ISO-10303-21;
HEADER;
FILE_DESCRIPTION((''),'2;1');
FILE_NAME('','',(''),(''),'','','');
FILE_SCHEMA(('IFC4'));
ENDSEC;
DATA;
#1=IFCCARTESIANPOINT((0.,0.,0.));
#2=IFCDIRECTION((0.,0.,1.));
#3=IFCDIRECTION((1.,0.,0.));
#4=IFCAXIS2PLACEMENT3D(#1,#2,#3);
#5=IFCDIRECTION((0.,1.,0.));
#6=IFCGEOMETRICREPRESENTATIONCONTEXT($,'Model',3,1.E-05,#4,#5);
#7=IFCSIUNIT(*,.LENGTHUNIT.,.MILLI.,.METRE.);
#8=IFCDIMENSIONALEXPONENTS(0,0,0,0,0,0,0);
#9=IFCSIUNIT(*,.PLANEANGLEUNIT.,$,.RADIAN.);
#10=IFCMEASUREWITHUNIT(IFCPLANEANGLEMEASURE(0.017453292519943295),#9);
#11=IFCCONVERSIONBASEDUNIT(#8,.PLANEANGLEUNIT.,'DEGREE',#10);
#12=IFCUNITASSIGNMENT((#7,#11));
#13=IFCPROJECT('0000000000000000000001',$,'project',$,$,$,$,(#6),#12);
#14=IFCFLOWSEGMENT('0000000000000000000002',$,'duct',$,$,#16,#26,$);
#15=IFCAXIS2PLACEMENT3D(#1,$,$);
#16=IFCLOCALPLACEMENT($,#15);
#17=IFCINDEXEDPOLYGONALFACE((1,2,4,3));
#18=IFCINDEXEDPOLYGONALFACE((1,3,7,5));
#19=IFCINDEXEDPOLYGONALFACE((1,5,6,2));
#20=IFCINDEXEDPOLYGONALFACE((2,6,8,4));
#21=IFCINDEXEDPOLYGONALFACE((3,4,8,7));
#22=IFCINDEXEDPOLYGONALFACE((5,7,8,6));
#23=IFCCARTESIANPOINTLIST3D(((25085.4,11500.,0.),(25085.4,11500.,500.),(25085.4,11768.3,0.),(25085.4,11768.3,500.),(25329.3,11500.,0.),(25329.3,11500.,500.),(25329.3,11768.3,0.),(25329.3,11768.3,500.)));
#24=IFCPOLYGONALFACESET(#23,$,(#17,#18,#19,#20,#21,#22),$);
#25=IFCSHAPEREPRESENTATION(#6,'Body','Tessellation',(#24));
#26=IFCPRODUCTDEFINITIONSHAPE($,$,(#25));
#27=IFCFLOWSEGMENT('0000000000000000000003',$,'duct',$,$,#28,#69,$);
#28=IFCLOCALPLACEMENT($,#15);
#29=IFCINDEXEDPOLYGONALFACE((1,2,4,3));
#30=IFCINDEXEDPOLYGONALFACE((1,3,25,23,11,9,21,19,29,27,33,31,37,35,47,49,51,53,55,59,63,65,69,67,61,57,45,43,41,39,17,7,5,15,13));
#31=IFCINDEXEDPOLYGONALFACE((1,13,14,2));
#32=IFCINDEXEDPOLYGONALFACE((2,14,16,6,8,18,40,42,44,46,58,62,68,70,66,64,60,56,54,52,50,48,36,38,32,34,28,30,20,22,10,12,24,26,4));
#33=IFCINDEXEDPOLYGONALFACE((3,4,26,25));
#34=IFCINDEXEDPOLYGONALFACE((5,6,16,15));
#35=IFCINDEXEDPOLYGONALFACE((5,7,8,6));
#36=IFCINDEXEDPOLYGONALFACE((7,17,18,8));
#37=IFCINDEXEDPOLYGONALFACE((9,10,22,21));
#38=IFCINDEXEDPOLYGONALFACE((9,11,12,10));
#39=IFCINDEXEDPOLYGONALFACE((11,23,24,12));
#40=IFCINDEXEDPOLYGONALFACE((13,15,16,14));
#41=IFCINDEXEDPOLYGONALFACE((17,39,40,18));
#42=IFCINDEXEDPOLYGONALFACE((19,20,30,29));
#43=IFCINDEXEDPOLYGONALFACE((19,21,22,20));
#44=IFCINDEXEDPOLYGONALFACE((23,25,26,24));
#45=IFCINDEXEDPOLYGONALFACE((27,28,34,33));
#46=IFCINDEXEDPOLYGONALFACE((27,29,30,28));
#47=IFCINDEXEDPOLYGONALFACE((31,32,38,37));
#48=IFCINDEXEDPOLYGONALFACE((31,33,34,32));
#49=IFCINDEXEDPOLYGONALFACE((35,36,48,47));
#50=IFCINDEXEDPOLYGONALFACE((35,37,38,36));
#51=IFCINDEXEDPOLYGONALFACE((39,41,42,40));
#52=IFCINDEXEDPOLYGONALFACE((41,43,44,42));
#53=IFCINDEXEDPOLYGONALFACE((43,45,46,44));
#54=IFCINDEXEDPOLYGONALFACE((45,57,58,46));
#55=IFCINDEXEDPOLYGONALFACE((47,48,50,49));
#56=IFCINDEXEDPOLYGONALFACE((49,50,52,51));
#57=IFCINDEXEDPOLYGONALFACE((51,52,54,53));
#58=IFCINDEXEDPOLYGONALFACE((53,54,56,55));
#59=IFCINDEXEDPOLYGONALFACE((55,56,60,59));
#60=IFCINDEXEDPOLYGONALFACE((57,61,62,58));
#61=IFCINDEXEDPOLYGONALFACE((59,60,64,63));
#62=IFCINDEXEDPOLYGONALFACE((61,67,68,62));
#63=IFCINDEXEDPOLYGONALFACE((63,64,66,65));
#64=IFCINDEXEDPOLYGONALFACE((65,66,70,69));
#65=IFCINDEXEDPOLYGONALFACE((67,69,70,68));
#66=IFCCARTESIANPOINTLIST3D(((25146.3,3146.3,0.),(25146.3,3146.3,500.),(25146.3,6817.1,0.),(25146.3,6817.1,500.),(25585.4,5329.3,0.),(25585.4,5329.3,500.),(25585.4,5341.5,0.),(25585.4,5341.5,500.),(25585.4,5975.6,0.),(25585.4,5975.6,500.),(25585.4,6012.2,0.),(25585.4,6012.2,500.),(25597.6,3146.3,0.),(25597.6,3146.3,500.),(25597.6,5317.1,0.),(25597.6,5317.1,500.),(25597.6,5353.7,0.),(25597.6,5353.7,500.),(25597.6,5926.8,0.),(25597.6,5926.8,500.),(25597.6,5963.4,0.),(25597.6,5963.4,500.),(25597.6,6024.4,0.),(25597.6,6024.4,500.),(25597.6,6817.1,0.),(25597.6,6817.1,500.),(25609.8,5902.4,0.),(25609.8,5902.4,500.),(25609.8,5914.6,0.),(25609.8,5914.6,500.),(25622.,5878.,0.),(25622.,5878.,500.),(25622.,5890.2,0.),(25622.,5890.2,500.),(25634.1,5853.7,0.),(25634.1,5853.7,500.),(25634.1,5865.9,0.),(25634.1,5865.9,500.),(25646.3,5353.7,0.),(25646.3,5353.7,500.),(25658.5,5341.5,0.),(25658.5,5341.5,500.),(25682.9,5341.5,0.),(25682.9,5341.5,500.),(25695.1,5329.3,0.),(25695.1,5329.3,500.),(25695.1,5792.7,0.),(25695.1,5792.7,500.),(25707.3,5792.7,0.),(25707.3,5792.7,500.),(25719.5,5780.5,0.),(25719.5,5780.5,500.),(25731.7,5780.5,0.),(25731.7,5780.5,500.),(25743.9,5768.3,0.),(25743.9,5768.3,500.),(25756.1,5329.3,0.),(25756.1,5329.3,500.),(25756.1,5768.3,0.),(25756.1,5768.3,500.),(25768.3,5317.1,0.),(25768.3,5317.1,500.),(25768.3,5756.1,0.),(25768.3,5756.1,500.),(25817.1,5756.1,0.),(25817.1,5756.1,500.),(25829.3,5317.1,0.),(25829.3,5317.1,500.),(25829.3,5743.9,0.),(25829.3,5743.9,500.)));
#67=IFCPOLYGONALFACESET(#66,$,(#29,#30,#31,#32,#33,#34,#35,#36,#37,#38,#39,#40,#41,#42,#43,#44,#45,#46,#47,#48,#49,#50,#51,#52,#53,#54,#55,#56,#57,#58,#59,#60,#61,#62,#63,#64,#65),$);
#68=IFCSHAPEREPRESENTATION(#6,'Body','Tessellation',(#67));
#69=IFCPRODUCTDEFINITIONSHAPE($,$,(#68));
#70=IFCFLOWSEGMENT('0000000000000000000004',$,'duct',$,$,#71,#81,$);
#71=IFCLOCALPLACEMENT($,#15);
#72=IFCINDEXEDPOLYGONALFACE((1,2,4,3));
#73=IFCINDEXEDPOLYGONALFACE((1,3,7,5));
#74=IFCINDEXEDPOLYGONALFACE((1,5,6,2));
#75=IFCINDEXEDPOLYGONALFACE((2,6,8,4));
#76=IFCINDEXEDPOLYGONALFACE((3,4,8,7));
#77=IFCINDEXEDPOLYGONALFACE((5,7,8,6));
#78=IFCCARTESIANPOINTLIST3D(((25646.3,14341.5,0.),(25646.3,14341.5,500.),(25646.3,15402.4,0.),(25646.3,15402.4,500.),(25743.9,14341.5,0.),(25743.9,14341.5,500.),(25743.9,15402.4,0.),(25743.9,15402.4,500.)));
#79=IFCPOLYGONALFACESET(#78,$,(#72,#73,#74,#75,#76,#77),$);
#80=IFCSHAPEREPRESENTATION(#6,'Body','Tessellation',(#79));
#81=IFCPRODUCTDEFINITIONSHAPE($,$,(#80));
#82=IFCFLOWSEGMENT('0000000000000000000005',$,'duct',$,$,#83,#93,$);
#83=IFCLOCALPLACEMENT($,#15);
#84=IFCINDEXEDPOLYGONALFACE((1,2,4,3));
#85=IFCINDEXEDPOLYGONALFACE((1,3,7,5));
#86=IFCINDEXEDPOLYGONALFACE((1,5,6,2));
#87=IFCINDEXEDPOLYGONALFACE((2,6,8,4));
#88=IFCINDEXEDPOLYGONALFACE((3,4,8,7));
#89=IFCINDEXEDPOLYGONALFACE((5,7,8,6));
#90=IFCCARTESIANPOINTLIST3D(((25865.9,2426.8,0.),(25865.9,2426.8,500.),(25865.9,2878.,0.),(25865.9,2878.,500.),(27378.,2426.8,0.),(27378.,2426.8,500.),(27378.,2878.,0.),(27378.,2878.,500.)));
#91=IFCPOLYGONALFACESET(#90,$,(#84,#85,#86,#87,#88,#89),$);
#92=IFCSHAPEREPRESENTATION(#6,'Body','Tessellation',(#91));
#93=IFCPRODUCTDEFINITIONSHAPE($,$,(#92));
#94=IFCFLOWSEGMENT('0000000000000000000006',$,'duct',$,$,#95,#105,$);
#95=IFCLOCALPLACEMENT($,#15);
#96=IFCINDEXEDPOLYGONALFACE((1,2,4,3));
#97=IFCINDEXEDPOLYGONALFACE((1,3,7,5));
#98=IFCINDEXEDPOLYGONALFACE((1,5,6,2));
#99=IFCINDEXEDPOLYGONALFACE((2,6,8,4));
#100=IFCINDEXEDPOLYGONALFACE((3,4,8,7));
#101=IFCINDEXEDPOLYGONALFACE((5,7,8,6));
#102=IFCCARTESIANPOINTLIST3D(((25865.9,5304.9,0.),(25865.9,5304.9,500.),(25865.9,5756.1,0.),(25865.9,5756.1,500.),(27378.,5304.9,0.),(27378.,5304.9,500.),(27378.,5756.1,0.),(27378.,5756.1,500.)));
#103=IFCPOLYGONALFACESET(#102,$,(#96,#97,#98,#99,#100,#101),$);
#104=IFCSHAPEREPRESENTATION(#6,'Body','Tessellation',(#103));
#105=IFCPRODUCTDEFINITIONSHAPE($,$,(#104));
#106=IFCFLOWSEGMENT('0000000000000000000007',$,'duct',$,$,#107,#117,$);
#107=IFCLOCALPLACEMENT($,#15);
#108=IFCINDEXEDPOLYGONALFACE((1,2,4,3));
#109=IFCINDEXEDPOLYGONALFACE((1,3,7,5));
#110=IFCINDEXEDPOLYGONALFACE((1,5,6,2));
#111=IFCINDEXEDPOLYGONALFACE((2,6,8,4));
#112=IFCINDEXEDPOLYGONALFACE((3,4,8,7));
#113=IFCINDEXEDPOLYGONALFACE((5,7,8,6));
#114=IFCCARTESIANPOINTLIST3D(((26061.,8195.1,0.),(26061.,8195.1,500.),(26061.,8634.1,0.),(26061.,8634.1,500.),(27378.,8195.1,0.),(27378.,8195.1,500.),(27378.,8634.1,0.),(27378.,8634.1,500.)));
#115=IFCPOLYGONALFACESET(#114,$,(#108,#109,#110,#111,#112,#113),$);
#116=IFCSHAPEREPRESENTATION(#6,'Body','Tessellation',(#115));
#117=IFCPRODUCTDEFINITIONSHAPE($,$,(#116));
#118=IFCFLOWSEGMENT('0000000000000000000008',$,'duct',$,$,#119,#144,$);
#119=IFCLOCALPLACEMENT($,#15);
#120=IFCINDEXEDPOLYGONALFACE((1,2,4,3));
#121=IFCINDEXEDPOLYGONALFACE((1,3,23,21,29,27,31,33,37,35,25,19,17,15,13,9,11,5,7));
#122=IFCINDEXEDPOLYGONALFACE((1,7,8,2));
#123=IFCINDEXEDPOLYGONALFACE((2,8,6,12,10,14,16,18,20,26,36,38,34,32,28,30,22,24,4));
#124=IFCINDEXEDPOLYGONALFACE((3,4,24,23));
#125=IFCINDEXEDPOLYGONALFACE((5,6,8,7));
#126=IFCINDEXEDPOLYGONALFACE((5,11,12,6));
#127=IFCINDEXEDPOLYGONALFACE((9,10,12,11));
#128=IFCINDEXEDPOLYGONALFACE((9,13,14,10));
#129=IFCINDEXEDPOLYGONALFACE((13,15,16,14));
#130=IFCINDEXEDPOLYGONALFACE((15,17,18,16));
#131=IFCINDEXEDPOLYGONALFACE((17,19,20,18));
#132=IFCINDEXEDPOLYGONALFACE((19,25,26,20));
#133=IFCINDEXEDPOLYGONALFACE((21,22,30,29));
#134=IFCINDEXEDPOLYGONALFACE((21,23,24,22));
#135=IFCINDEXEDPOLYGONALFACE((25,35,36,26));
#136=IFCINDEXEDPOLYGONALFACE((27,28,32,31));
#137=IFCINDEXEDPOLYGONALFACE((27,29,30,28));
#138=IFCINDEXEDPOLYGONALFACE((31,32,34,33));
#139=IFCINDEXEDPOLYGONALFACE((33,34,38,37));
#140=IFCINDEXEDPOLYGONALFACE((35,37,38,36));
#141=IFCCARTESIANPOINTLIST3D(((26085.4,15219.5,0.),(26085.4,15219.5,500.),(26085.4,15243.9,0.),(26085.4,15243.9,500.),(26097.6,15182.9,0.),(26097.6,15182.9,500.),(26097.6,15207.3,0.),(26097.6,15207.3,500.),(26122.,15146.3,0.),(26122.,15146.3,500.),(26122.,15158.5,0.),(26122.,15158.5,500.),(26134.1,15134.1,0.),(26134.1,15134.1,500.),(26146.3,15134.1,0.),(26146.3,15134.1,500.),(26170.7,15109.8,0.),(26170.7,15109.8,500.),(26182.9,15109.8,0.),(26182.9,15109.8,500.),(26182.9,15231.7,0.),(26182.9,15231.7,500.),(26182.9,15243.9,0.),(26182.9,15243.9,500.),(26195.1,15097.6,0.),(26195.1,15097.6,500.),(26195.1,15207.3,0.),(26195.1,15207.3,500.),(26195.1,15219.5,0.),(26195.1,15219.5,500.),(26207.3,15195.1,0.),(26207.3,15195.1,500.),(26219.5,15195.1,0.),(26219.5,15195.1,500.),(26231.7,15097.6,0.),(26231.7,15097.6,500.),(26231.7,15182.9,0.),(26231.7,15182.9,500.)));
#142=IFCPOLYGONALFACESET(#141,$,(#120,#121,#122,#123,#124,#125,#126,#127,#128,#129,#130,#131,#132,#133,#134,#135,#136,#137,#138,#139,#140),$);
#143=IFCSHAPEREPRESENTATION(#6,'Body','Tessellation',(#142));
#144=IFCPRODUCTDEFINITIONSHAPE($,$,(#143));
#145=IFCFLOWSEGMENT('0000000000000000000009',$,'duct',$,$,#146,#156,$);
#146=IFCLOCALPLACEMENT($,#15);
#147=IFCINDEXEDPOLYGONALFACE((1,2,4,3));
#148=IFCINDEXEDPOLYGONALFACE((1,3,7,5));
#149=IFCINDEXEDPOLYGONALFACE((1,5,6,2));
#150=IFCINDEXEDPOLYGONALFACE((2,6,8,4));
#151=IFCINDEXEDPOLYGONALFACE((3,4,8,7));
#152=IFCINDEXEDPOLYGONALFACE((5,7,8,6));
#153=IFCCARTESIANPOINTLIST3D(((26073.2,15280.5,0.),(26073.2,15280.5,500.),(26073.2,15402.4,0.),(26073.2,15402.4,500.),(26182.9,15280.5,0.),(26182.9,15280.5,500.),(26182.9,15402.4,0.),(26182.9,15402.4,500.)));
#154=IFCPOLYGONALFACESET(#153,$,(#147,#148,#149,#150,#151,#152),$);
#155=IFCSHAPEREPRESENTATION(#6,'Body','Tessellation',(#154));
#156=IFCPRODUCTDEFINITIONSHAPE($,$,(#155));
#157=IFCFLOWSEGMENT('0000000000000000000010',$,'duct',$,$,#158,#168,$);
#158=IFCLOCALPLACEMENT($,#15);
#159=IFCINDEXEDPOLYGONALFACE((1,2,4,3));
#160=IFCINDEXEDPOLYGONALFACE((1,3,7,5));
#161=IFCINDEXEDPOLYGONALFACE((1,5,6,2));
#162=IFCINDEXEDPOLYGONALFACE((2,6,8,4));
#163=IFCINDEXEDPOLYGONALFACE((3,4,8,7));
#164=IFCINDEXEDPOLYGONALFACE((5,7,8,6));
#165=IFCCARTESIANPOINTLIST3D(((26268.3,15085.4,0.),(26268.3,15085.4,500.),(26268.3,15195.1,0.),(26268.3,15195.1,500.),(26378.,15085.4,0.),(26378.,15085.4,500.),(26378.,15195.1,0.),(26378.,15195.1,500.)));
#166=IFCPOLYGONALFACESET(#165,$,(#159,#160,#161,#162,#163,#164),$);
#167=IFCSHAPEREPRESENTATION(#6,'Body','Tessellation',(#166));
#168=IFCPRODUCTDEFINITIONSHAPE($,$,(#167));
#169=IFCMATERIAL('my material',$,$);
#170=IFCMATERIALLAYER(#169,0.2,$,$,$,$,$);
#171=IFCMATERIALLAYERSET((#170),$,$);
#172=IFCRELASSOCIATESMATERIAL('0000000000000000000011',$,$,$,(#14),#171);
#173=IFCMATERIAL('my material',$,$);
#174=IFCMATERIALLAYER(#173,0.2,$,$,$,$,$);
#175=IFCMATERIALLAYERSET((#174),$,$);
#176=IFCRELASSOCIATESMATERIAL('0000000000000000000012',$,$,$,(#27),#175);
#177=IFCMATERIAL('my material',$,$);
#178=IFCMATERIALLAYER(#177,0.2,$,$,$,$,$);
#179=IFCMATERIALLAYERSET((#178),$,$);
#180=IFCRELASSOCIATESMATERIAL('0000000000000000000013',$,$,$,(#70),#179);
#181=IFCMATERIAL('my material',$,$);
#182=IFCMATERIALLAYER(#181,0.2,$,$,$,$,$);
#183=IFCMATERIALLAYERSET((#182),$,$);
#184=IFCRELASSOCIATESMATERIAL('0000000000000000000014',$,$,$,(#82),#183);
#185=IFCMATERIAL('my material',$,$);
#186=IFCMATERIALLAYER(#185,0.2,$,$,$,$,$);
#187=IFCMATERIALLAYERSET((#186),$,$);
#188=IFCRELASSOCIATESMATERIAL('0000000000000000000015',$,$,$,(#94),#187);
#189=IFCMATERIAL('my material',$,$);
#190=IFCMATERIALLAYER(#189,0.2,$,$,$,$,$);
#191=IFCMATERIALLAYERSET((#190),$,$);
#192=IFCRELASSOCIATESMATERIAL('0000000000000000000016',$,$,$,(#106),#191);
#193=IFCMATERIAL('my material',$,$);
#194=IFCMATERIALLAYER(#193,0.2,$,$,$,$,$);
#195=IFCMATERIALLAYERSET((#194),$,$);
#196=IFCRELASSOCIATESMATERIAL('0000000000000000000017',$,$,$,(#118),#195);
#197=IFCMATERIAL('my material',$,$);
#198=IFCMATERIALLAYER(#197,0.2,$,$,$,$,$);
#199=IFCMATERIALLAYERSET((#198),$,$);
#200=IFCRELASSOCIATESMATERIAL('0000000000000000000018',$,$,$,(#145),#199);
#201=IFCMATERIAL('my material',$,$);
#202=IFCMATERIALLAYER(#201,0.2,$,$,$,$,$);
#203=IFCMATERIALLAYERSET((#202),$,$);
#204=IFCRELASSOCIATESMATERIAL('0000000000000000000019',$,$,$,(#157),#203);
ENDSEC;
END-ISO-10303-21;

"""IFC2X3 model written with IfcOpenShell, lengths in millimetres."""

from ifc_helpers import new_model, entity, si_unit, converted_unit, direction, origin_with_axes, place, context, project, polyline, outline, extrude, material, layer, layer_set, layer_usage, element, save


model = new_model("IFC2X3")

# Units and contexts
model_context = context("Model", 3, precision=1e-05, world=origin_with_axes(), true_north=direction((0.0, 1.0, 0.0)))
ifc_project = project(units=[si_unit("LENGTHUNIT", "METRE", prefix="MILLI"), converted_unit("PLANEANGLEUNIT", "DEGREE", entity("IfcPlaneAngleMeasure", 0.017453292519943295), si_unit("PLANEANGLEUNIT", "RADIAN"), dimensions=[0, 0, 0, 0, 0, 0, 0])], contexts=[model_context])

# Flow segments
ifc_material_1 = material(Name="my material")
ifc_layer_1 = layer(ifc_material_1, 0.2)
ifc_layer_set_1 = layer_set([ifc_layer_1])
ifc_layer_usage_1 = layer_usage(ifc_layer_set_1, "AXIS2", "POSITIVE", -0.1)
flow_segment_1_placement = place(None, origin_with_axes())
element("IfcFlowSegment", 1, at=flow_segment_1_placement, material=ifc_layer_usage_1, Name="duct", context=model_context, shape_type="SweptSolid", body=[
    extrude(outline(polyline([(25085.4, 11500.0), (25329.3, 11500.0), (25329.3, 11768.3), (25085.4, 11768.3), (25085.4, 11500.0)])), origin_with_axes(), (0.0, 0.0, 1.0), 500.0),
])
ifc_material_2 = material(Name="my material")
ifc_layer_2 = layer(ifc_material_2, 0.2)
ifc_layer_set_2 = layer_set([ifc_layer_2])
ifc_layer_usage_2 = layer_usage(ifc_layer_set_2, "AXIS2", "POSITIVE", -0.1)
flow_segment_2_placement = place(None, origin_with_axes())
element("IfcFlowSegment", 2, at=flow_segment_2_placement, material=ifc_layer_usage_2, Name="duct", context=model_context, shape_type="SweptSolid", body=[
    extrude(outline(polyline([(25146.3, 3146.3), (25597.6, 3146.3), (25597.6, 5317.1), (25585.4, 5329.3), (25585.4, 5341.5), (25597.6, 5353.7), (25646.3, 5353.7), (25658.5, 5341.5), (25682.9, 5341.5), (25695.1, 5329.3), (25756.1, 5329.3), (25768.3, 5317.1), (25829.3, 5317.1), (25829.3, 5743.9), (25817.1, 5756.1), (25768.3, 5756.1), (25756.1, 5768.3), (25743.9, 5768.3), (25731.7, 5780.5), (25719.5, 5780.5), (25707.3, 5792.7), (25695.1, 5792.7), (25634.1, 5853.7), (25634.1, 5865.9), (25622.0, 5878.0), (25622.0, 5890.2), (25609.8, 5902.4), (25609.8, 5914.6), (25597.6, 5926.8), (25597.6, 5963.4), (25585.4, 5975.6), (25585.4, 6012.2), (25597.6, 6024.4), (25597.6, 6817.1), (25146.3, 6817.1), (25146.3, 3146.3)])), origin_with_axes(), (0.0, 0.0, 1.0), 500.0),
])
ifc_material_3 = material(Name="my material")
ifc_layer_3 = layer(ifc_material_3, 0.2)
ifc_layer_set_3 = layer_set([ifc_layer_3])
ifc_layer_usage_3 = layer_usage(ifc_layer_set_3, "AXIS2", "POSITIVE", -0.1)
flow_segment_3_placement = place(None, origin_with_axes())
element("IfcFlowSegment", 3, at=flow_segment_3_placement, material=ifc_layer_usage_3, Name="duct", context=model_context, shape_type="SweptSolid", body=[
    extrude(outline(polyline([(25646.3, 14341.5), (25743.9, 14341.5), (25743.9, 15402.4), (25646.3, 15402.4), (25646.3, 14341.5)])), origin_with_axes(), (0.0, 0.0, 1.0), 500.0),
])
ifc_material_4 = material(Name="my material")
ifc_layer_4 = layer(ifc_material_4, 0.2)
ifc_layer_set_4 = layer_set([ifc_layer_4])
ifc_layer_usage_4 = layer_usage(ifc_layer_set_4, "AXIS2", "POSITIVE", -0.1)
flow_segment_4_placement = place(None, origin_with_axes())
element("IfcFlowSegment", 4, at=flow_segment_4_placement, material=ifc_layer_usage_4, Name="duct", context=model_context, shape_type="SweptSolid", body=[
    extrude(outline(polyline([(25865.9, 2426.8), (27378.0, 2426.8), (27378.0, 2878.0), (25865.9, 2878.0), (25865.9, 2426.8)])), origin_with_axes(), (0.0, 0.0, 1.0), 500.0),
])
ifc_material_5 = material(Name="my material")
ifc_layer_5 = layer(ifc_material_5, 0.2)
ifc_layer_set_5 = layer_set([ifc_layer_5])
ifc_layer_usage_5 = layer_usage(ifc_layer_set_5, "AXIS2", "POSITIVE", -0.1)
flow_segment_5_placement = place(None, origin_with_axes())
element("IfcFlowSegment", 5, at=flow_segment_5_placement, material=ifc_layer_usage_5, Name="duct", context=model_context, shape_type="SweptSolid", body=[
    extrude(outline(polyline([(25865.9, 5304.9), (27378.0, 5304.9), (27378.0, 5756.1), (25865.9, 5756.1), (25865.9, 5304.9)])), origin_with_axes(), (0.0, 0.0, 1.0), 500.0),
])
ifc_material_6 = material(Name="my material")
ifc_layer_6 = layer(ifc_material_6, 0.2)
ifc_layer_set_6 = layer_set([ifc_layer_6])
ifc_layer_usage_6 = layer_usage(ifc_layer_set_6, "AXIS2", "POSITIVE", -0.1)
flow_segment_6_placement = place(None, origin_with_axes())
element("IfcFlowSegment", 6, at=flow_segment_6_placement, material=ifc_layer_usage_6, Name="duct", context=model_context, shape_type="SweptSolid", body=[
    extrude(outline(polyline([(26061.0, 8195.1), (27378.0, 8195.1), (27378.0, 8634.1), (26061.0, 8634.1), (26061.0, 8195.1)])), origin_with_axes(), (0.0, 0.0, 1.0), 500.0),
])
ifc_material_7 = material(Name="my material")
ifc_layer_7 = layer(ifc_material_7, 0.2)
ifc_layer_set_7 = layer_set([ifc_layer_7])
ifc_layer_usage_7 = layer_usage(ifc_layer_set_7, "AXIS2", "POSITIVE", -0.1)
flow_segment_7_placement = place(None, origin_with_axes())
element("IfcFlowSegment", 7, at=flow_segment_7_placement, material=ifc_layer_usage_7, Name="duct", context=model_context, shape_type="SweptSolid", body=[
    extrude(outline(polyline([(26085.4, 15219.5), (26097.6, 15207.3), (26097.6, 15182.9), (26122.0, 15158.5), (26122.0, 15146.3), (26134.1, 15134.1), (26146.3, 15134.1), (26170.7, 15109.8), (26182.9, 15109.8), (26195.1, 15097.6), (26231.7, 15097.6), (26231.7, 15182.9), (26219.5, 15195.1), (26207.3, 15195.1), (26195.1, 15207.3), (26195.1, 15219.5), (26182.9, 15231.7), (26182.9, 15243.9), (26085.4, 15243.9), (26085.4, 15219.5)])), origin_with_axes(), (0.0, 0.0, 1.0), 500.0),
])
ifc_material_8 = material(Name="my material")
ifc_layer_8 = layer(ifc_material_8, 0.2)
ifc_layer_set_8 = layer_set([ifc_layer_8])
ifc_layer_usage_8 = layer_usage(ifc_layer_set_8, "AXIS2", "POSITIVE", -0.1)
flow_segment_8_placement = place(None, origin_with_axes())
element("IfcFlowSegment", 8, at=flow_segment_8_placement, material=ifc_layer_usage_8, Name="duct", context=model_context, shape_type="SweptSolid", body=[
    extrude(outline(polyline([(26073.2, 15280.5), (26182.9, 15280.5), (26182.9, 15402.4), (26073.2, 15402.4), (26073.2, 15280.5)])), origin_with_axes(), (0.0, 0.0, 1.0), 500.0),
])
ifc_material_9 = material(Name="my material")
ifc_layer_9 = layer(ifc_material_9, 0.2)
ifc_layer_set_9 = layer_set([ifc_layer_9])
ifc_layer_usage_9 = layer_usage(ifc_layer_set_9, "AXIS2", "POSITIVE", -0.1)
flow_segment_9_placement = place(None, origin_with_axes())
element("IfcFlowSegment", 9, at=flow_segment_9_placement, material=ifc_layer_usage_9, Name="duct", context=model_context, shape_type="SweptSolid", body=[
    extrude(outline(polyline([(26268.3, 15085.4), (26378.0, 15085.4), (26378.0, 15195.1), (26268.3, 15195.1), (26268.3, 15085.4)])), origin_with_axes(), (0.0, 0.0, 1.0), 500.0),
])

save(model, "model.ifc")
